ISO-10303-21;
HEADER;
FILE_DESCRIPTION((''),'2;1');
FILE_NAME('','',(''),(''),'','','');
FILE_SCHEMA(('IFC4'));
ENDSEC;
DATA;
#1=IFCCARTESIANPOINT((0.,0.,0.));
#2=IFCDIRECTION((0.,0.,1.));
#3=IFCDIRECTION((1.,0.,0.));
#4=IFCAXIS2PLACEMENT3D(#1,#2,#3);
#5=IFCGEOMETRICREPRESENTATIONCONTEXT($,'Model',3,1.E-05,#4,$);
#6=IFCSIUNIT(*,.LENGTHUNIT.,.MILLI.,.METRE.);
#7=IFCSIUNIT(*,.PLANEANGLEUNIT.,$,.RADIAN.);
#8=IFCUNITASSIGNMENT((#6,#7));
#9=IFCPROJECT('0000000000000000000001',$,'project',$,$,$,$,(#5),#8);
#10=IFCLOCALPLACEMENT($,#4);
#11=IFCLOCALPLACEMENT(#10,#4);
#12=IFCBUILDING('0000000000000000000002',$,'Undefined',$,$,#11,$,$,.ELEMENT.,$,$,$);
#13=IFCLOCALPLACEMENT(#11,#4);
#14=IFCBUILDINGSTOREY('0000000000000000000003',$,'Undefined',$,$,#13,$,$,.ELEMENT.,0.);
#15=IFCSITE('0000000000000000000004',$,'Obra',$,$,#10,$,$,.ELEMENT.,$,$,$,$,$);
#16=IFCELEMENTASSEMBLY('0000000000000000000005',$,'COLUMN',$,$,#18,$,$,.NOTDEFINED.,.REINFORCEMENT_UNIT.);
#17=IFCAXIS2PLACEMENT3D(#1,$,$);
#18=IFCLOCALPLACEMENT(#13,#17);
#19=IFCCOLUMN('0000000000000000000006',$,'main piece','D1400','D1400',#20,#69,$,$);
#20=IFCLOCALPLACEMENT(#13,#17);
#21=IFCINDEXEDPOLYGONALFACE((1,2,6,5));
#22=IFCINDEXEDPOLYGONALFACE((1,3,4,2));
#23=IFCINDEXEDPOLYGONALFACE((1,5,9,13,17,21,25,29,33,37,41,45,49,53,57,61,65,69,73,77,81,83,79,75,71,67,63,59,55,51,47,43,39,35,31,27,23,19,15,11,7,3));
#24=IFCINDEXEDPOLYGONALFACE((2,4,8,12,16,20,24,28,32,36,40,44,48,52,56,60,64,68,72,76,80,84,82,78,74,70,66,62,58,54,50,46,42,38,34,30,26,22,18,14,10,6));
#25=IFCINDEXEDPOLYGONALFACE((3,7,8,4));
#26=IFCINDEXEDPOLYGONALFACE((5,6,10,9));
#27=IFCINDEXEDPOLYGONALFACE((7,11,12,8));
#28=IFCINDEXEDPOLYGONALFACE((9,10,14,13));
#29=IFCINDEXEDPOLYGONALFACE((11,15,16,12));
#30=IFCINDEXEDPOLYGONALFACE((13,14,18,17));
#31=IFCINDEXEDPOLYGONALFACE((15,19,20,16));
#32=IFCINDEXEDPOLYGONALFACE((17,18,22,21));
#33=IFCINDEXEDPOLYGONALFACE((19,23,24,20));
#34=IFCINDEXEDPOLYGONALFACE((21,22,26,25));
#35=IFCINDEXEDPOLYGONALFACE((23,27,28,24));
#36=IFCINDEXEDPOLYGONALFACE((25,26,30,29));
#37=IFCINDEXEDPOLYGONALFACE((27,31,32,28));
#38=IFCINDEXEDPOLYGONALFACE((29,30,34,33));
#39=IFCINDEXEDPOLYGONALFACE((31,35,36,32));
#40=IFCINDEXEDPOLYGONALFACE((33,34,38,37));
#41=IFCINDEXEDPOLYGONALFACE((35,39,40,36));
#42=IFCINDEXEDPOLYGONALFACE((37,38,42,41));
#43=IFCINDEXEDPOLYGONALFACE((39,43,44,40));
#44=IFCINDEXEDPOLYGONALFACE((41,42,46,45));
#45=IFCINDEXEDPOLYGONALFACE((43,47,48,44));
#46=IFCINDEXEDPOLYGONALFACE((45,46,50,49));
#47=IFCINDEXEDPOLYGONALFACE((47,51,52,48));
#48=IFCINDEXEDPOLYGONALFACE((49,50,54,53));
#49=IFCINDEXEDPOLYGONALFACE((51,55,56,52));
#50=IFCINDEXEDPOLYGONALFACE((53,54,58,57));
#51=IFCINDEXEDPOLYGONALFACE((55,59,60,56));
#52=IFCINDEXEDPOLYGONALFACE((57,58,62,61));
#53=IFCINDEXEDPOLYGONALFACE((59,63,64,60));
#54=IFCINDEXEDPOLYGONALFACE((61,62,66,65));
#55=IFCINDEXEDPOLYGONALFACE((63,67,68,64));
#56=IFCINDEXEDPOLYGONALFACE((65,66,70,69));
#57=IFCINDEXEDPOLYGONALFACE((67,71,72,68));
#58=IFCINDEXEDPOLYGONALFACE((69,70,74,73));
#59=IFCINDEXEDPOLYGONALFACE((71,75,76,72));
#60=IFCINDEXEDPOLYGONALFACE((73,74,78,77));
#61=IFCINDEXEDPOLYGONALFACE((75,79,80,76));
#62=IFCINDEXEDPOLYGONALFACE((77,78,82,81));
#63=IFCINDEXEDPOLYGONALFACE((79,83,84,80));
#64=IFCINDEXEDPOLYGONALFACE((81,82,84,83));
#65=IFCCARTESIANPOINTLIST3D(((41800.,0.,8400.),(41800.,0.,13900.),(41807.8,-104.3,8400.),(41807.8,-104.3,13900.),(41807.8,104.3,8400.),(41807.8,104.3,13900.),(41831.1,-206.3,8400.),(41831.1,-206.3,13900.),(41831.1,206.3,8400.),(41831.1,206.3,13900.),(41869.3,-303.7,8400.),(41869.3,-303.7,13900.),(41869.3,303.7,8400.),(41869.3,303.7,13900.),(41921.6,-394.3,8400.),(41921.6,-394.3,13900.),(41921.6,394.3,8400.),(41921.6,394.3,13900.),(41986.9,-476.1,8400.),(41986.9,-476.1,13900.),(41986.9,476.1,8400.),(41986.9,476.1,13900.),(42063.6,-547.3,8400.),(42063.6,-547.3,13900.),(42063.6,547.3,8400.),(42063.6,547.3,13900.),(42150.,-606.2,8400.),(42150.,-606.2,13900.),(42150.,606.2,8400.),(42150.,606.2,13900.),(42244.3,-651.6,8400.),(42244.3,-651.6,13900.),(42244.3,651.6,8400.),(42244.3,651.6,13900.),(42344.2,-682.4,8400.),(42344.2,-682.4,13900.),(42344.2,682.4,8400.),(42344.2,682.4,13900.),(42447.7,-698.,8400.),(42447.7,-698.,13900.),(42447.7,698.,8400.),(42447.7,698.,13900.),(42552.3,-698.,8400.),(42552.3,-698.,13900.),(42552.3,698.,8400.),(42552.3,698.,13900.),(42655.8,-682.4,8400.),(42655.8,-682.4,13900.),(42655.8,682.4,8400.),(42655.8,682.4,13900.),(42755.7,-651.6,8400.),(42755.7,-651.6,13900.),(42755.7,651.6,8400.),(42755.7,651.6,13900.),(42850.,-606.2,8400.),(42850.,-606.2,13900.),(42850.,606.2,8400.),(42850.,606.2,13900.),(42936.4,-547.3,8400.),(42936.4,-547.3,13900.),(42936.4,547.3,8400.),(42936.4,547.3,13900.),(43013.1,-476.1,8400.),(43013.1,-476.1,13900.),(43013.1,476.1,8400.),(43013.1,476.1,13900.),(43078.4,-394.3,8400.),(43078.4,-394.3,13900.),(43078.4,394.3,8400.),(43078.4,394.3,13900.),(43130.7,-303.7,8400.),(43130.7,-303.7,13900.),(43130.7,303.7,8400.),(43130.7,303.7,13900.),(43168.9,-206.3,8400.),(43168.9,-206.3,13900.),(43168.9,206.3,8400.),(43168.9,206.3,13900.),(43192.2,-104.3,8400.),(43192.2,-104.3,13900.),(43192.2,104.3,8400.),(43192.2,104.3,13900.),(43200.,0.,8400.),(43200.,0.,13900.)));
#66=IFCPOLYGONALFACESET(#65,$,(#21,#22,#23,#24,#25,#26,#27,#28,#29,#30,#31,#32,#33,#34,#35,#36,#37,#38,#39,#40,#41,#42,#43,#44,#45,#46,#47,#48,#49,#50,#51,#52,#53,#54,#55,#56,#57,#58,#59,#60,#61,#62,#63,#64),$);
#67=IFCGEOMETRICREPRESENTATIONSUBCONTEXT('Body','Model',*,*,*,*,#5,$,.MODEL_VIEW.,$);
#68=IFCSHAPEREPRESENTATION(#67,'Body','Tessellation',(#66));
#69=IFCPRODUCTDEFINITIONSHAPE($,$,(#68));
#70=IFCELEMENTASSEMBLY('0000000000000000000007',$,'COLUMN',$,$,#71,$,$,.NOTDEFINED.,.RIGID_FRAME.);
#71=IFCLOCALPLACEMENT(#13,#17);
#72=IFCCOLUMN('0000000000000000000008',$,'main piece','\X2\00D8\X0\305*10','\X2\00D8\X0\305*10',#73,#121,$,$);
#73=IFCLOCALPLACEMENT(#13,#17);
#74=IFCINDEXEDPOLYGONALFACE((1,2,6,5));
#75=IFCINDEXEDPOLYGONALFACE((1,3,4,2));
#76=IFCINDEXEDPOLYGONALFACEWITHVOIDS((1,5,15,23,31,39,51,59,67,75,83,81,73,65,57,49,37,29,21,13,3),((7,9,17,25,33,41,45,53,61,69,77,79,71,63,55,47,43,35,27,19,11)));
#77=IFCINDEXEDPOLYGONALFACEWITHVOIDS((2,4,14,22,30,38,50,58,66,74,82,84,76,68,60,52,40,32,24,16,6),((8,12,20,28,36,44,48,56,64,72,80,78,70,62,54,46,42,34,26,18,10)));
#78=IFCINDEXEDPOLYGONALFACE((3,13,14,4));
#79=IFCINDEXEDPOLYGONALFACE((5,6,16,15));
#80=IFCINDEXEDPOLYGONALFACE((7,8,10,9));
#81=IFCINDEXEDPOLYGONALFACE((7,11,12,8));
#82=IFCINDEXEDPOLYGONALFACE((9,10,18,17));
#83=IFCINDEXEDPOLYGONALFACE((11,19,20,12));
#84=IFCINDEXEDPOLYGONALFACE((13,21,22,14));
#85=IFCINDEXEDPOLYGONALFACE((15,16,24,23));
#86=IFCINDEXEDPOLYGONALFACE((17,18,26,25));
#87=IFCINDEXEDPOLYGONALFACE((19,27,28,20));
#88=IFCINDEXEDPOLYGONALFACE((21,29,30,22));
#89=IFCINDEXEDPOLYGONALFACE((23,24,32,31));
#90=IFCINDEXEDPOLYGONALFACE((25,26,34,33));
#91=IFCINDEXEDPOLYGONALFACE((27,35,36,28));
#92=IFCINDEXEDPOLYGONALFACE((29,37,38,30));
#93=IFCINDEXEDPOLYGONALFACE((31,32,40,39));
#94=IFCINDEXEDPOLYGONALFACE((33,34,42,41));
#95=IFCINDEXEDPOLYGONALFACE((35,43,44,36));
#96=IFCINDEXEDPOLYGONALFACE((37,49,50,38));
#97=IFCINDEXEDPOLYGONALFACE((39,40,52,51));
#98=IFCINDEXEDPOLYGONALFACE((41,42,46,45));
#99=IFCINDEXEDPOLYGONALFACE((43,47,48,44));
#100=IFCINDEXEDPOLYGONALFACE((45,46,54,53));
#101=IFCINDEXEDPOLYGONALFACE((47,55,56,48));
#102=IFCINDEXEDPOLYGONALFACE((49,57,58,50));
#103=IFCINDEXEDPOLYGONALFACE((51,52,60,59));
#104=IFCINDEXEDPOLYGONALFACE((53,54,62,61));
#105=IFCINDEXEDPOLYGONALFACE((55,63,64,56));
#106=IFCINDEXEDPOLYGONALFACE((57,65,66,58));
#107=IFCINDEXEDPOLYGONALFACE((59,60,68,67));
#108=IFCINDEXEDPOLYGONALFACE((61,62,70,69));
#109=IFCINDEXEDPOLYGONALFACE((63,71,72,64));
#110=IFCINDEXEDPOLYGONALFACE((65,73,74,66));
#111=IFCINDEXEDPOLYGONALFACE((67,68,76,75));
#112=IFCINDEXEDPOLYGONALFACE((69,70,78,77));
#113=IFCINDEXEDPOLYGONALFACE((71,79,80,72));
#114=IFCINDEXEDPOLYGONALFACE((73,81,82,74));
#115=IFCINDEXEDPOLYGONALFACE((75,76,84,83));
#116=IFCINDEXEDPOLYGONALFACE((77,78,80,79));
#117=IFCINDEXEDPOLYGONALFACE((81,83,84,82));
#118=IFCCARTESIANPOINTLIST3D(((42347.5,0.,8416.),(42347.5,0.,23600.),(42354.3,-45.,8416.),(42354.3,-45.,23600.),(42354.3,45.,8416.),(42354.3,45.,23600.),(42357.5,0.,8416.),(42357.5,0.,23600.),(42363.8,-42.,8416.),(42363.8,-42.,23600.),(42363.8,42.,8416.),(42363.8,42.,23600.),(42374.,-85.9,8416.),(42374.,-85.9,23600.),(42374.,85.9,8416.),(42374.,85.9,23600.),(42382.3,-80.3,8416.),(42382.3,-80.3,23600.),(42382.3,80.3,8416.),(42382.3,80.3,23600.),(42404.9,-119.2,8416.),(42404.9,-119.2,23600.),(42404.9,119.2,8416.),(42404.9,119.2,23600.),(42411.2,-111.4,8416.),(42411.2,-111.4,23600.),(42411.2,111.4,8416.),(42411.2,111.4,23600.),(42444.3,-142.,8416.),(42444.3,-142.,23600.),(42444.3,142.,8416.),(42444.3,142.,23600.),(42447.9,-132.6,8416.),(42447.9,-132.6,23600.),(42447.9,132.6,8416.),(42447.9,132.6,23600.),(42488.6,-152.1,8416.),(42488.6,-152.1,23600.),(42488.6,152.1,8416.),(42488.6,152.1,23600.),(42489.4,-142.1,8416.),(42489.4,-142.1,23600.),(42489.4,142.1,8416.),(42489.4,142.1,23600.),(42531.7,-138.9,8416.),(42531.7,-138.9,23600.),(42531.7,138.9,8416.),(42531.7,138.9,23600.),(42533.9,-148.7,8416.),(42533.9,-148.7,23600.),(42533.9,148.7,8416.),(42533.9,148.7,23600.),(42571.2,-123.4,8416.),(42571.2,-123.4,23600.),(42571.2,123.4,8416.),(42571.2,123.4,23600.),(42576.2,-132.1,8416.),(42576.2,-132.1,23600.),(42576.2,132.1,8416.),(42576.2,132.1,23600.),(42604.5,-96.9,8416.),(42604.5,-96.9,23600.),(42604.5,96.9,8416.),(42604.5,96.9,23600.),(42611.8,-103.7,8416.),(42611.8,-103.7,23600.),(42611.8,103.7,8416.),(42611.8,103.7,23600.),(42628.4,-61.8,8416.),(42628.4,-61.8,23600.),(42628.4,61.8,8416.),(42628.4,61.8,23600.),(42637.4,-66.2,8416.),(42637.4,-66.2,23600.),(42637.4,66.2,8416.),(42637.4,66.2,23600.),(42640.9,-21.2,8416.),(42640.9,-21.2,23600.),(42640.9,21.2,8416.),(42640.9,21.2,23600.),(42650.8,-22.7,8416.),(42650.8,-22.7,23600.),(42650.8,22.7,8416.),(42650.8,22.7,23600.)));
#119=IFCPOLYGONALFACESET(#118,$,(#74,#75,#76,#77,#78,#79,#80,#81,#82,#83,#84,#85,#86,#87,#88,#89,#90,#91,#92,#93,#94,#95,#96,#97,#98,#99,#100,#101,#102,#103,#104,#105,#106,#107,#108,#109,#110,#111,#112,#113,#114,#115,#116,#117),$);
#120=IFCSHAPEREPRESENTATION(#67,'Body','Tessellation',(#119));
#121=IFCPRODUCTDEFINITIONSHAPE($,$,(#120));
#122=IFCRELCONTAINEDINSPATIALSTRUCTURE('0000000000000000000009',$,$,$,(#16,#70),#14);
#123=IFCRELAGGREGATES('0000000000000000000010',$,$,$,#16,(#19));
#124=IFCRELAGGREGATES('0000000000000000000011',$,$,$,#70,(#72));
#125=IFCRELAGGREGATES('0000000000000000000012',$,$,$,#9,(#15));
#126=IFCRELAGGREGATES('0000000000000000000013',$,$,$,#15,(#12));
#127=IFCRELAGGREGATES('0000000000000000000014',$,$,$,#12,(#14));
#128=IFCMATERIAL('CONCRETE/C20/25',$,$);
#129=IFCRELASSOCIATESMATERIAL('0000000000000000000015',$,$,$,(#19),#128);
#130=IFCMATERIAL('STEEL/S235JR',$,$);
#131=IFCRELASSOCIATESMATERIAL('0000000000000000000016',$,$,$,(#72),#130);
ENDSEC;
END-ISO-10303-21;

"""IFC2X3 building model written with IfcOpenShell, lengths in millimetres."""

from ifc_helpers import new_model, si_unit, frame, origin_with_axes, origin_2d_with_axis, place, context, subcontext, project, spatial, circle, hollow_circle, extrude, clip, halfspace, material, element, aggregate, save


model = new_model("IFC2X3")

# Units and contexts
model_context = context("Model", 3, precision=1e-05, world=origin_with_axes())
body_context = subcontext(model_context, "Body", "Model", "MODEL_VIEW")
ifc_project = project(units=[si_unit("LENGTHUNIT", "METRE", prefix="MILLI"), si_unit("PLANEANGLEUNIT", "RADIAN")], contexts=[model_context])

# Site, building, storey
site_placement = place(None, origin_with_axes())
site = spatial("IfcSite", under=ifc_project, at=site_placement, Name="Obra", CompositionType="ELEMENT")
building_placement = place(site_placement, origin_with_axes())
building = spatial("IfcBuilding", under=site, at=building_placement, Name="Undefined", CompositionType="ELEMENT")
storey_placement = place(building_placement, origin_with_axes())
storey = spatial("IfcBuildingStorey", under=building, at=storey_placement, Name="Undefined", CompositionType="ELEMENT", Elevation=0.0)

# Element assembly, column
assembly_1_placement = place(storey_placement, origin_with_axes())
assembly_1 = element("IfcElementAssembly", 1, at=assembly_1_placement, inside=storey, Name="COLUMN", AssemblyPlace="NOTDEFINED", PredefinedType="REINFORCEMENT_UNIT")
ifc_material_1 = material(Name="CONCRETE/C20/25")
column_1_placement = place(assembly_1_placement, frame((42500.0, 0.0, 8400.0), z_axis=(0.0, 0.0, 1.0), x_axis=(0.0, 1.0, 0.0)))
column_1 = element("IfcColumn", 2, at=column_1_placement, material=ifc_material_1, Name="main piece", Description="D1400", ObjectType="D1400", context=body_context, shape_type="SweptSolid", body=[
    extrude(circle(Radius=700.0, at=origin_2d_with_axis()), frame((0.0, 0.0, 5500.0), z_axis=(0.0, 0.0, -1.0), x_axis=(0.0, 1.0, 0.0)), (0.0, 0.0, 1.0), 5500.0),
])
aggregate(assembly_1, [column_1])

# Element assembly, column
assembly_2_placement = place(storey_placement, origin_with_axes())
assembly_2 = element("IfcElementAssembly", 3, at=assembly_2_placement, inside=storey, Name="COLUMN", AssemblyPlace="NOTDEFINED", PredefinedType="RIGID_FRAME")
ifc_material_2 = material(Name="STEEL/S235JR")
column_2_placement = place(assembly_2_placement, frame((42500.0, 0.0, 8400.0), z_axis=(0.0, 0.0, 1.0), x_axis=(0.0, 1.0, 0.0)))
column_2 = element("IfcColumn", 4, at=column_2_placement, material=ifc_material_2, Name="main piece", Description="Ø305*10", ObjectType="Ø305*10", context=body_context, shape_type="Clipping", body=[
    clip(extrude(hollow_circle(Radius=152.5, WallThickness=10.0, at=origin_2d_with_axis()), frame((0.0, 0.0, 15200.0), z_axis=(0.0, 0.0, -1.0), x_axis=(0.0, 1.0, 0.0)), (0.0, 0.0, 1.0), 15184.0), halfspace(frame((-152.5, 0.0, 16.0), z_axis=(0.0, 0.0, 1.0), x_axis=(0.0, 1.0, 0.0)), True)),
])

aggregate(assembly_2, [column_2])

save(model, "model.ifc")
